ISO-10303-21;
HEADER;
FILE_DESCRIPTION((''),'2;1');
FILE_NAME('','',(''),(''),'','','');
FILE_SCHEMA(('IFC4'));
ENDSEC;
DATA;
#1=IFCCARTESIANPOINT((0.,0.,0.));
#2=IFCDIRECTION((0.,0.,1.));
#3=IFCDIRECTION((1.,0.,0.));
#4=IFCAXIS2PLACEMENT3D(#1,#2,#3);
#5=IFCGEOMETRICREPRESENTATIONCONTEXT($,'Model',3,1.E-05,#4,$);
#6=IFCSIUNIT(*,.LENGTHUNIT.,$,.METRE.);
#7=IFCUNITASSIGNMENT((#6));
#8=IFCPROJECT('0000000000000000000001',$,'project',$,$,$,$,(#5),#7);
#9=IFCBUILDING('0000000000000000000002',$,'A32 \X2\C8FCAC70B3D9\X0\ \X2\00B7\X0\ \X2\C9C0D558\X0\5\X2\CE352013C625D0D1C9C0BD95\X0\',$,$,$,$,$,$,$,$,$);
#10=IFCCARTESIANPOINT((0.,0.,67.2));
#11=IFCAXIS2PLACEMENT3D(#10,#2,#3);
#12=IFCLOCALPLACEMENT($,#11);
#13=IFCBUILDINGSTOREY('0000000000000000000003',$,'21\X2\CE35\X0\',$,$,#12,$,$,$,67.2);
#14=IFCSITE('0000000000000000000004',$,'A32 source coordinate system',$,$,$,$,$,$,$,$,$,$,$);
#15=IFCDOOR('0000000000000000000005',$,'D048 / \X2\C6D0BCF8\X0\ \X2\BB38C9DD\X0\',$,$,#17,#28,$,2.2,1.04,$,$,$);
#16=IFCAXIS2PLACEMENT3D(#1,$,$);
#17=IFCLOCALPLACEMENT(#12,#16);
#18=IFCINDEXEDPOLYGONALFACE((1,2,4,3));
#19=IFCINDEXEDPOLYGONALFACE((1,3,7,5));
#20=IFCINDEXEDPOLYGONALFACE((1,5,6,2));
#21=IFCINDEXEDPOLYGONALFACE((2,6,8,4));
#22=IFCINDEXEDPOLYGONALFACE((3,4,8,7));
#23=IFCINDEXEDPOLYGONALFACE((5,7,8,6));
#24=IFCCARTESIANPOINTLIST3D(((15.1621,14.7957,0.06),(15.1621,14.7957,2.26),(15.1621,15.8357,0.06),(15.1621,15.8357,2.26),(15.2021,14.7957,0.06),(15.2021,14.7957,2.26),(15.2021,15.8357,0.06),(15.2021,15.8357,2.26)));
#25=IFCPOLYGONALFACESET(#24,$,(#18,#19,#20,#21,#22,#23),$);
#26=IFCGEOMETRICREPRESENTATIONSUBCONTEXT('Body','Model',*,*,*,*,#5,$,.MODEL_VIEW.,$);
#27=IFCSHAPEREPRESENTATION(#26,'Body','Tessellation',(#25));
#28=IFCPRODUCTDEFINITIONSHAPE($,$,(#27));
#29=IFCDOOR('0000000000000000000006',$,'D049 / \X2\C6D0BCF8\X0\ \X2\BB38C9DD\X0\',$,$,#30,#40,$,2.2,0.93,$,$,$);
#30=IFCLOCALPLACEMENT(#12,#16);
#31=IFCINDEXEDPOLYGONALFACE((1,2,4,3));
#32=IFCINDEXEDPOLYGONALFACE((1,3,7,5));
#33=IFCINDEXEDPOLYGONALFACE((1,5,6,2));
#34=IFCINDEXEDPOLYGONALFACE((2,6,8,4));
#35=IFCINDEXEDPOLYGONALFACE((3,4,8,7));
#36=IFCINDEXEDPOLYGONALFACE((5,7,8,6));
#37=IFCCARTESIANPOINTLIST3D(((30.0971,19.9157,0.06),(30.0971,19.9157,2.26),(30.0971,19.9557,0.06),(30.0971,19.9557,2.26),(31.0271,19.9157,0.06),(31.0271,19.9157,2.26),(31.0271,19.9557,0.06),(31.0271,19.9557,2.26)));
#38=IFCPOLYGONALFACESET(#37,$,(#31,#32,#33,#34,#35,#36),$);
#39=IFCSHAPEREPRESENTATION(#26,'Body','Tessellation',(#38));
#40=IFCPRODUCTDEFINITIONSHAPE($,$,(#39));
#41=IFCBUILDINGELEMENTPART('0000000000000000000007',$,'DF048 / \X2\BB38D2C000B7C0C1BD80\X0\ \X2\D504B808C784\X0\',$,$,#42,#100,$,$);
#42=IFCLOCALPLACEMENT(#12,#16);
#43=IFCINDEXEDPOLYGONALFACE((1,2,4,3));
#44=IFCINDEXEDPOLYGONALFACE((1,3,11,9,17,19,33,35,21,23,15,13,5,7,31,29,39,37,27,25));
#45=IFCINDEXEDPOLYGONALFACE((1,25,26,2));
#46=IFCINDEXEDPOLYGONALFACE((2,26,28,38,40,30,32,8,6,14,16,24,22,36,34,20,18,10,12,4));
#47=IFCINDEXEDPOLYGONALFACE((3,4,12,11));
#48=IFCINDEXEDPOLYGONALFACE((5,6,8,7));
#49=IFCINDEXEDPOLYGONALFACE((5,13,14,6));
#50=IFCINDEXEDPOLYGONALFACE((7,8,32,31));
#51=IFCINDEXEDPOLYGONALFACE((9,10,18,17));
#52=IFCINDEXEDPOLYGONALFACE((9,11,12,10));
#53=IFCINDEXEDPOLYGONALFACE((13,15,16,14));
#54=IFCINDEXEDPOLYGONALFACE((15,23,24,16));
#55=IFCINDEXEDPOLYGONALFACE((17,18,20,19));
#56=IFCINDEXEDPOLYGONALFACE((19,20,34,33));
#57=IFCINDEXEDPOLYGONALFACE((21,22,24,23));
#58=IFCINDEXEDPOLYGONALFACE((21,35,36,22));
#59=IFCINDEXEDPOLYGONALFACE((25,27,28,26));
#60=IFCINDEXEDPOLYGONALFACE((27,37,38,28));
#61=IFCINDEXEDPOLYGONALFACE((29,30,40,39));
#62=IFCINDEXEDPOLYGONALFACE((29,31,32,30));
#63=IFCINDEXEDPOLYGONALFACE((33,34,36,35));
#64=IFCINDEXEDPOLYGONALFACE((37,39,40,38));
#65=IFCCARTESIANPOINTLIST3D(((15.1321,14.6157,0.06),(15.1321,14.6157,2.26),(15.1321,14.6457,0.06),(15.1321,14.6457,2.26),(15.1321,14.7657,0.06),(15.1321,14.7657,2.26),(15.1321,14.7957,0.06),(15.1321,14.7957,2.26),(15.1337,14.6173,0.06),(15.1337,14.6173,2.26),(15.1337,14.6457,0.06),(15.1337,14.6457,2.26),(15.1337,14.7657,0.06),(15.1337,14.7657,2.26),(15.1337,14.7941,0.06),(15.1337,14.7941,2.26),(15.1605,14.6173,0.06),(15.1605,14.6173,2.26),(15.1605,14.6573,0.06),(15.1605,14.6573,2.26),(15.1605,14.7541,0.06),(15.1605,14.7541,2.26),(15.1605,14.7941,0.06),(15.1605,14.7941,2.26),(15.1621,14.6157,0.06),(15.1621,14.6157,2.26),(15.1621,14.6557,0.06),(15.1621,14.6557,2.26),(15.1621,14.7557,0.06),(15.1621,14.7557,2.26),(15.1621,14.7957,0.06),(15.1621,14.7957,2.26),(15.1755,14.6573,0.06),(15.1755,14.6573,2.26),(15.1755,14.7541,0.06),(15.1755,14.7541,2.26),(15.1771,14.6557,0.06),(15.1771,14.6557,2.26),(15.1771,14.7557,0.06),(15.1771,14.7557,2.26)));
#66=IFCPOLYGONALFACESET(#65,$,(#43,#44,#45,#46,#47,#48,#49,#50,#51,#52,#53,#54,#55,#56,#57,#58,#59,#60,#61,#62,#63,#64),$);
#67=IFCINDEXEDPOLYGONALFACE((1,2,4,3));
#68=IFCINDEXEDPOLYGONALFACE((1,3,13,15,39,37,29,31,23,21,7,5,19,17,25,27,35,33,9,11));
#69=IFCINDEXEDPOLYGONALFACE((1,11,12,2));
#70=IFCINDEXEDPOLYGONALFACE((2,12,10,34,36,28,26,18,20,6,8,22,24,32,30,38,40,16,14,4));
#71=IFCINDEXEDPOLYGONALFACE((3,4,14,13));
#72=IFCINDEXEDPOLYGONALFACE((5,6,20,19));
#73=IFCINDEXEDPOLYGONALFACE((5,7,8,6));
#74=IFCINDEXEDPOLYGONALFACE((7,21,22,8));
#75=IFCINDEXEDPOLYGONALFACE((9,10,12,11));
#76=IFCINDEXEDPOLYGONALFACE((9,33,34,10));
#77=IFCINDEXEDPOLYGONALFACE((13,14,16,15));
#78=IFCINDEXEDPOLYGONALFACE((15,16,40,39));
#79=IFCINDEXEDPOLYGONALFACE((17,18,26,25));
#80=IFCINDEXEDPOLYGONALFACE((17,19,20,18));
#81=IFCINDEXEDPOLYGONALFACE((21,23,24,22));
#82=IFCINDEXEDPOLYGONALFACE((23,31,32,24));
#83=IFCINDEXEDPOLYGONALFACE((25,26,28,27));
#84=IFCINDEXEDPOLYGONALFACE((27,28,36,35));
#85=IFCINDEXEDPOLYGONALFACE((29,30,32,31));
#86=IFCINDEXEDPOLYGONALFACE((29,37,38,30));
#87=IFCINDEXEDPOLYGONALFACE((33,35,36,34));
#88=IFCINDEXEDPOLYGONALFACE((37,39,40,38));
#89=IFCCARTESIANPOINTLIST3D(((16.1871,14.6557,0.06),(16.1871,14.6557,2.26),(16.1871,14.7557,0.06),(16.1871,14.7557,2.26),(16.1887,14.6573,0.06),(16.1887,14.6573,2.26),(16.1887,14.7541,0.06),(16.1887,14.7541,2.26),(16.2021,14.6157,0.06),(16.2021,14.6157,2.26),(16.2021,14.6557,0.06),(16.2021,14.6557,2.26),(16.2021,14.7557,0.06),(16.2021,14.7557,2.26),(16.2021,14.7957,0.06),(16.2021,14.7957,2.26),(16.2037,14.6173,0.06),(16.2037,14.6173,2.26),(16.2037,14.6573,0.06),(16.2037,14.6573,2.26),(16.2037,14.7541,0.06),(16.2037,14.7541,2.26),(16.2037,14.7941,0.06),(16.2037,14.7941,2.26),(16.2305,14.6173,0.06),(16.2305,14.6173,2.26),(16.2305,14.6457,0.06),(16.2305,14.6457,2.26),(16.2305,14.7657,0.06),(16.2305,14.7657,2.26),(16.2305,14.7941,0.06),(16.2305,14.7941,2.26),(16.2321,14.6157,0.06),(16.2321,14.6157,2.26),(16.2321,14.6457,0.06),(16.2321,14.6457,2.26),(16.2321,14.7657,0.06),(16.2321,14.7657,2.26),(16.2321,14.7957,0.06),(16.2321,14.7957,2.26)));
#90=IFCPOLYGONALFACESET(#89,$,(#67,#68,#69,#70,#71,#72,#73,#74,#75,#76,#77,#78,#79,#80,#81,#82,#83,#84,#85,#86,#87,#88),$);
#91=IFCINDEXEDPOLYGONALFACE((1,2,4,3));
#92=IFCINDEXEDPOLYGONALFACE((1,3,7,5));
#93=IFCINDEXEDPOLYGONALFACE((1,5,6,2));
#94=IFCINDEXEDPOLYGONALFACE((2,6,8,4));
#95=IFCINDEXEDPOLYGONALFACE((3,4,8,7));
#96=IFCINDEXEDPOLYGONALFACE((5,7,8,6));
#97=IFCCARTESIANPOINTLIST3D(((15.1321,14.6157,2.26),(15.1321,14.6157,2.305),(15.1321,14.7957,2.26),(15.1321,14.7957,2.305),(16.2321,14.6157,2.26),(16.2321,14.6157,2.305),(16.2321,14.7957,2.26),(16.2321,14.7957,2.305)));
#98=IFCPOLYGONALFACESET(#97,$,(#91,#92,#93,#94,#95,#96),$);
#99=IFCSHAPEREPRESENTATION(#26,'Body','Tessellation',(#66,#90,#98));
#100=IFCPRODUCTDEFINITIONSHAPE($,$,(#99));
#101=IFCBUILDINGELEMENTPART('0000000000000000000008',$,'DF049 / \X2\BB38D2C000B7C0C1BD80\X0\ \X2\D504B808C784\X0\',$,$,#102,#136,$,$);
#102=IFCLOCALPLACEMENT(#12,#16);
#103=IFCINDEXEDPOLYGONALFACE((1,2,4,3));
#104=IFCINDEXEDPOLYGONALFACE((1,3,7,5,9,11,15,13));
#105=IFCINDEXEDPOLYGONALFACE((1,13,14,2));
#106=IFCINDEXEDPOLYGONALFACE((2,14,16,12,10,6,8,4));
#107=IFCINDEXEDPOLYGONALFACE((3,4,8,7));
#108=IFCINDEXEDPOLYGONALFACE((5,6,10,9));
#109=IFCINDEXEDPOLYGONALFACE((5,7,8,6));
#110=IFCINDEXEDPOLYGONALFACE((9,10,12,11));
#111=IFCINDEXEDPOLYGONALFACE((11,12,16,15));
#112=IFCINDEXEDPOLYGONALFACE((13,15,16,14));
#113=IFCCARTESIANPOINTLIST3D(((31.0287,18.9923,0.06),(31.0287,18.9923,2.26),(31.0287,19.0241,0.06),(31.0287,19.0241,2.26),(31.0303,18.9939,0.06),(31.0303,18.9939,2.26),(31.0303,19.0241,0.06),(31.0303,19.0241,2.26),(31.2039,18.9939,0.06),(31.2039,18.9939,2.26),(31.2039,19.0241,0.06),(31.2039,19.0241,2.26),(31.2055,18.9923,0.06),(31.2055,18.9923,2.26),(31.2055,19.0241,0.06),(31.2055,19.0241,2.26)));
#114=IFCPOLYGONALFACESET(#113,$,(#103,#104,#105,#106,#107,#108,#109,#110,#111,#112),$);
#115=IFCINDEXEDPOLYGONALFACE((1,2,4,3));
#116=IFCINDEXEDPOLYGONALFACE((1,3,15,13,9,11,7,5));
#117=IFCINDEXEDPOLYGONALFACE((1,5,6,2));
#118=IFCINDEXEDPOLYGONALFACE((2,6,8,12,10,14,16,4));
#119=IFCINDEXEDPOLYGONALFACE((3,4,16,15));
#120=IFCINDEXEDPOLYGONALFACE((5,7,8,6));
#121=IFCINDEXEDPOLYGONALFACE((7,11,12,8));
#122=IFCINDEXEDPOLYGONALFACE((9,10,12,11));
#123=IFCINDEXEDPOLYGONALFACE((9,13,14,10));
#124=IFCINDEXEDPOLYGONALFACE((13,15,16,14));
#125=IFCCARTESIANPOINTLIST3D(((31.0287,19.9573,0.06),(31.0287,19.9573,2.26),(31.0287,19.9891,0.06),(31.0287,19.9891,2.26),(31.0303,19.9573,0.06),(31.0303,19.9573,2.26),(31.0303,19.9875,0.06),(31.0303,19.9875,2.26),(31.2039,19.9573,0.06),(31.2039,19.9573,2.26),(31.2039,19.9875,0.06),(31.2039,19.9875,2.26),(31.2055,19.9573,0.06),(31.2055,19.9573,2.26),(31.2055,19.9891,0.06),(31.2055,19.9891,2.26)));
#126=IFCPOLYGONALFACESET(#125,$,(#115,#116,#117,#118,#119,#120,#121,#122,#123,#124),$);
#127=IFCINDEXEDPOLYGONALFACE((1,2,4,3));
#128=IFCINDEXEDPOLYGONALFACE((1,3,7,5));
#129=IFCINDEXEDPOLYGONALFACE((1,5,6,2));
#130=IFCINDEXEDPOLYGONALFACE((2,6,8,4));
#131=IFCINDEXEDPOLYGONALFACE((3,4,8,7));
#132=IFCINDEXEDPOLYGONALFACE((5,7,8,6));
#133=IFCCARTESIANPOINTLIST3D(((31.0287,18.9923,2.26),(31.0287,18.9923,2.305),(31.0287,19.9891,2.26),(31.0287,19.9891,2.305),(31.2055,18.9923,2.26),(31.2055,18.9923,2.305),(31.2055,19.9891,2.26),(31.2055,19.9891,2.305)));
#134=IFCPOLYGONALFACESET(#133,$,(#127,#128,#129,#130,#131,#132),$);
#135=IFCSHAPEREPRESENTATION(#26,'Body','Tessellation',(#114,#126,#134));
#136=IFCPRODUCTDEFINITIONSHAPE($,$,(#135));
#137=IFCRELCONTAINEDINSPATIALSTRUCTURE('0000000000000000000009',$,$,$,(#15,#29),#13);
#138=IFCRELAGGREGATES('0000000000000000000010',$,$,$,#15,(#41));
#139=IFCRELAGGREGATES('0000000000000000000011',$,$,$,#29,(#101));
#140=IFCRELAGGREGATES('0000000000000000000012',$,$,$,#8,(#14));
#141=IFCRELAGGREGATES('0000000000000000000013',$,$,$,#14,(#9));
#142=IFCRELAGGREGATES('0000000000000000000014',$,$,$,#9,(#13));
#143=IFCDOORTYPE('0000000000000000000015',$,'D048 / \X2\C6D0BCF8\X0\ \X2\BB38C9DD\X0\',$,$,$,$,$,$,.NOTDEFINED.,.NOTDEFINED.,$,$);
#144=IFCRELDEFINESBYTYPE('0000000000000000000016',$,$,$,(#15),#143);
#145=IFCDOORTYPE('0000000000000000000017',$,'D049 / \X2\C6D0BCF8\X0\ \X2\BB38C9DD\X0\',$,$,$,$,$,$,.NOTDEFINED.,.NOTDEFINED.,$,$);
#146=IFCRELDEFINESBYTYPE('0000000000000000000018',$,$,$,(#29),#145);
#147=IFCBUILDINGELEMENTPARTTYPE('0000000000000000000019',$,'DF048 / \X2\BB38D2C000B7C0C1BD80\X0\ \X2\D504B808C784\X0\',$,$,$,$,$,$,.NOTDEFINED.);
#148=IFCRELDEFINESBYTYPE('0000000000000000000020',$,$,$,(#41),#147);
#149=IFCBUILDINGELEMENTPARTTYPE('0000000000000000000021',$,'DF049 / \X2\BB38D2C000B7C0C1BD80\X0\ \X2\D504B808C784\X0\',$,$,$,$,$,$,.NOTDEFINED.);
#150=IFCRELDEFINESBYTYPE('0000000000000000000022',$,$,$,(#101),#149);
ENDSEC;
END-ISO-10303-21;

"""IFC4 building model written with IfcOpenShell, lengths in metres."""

from ifc_helpers import new_model, si_unit, frame, origin, origin_with_axes, place, context, subcontext, project, spatial, polyline, outline, extrude, source, transform, mapped, type_object, type_shapes, element, aggregate, save


model = new_model("IFC4")

# Units and contexts
model_context = context("Model", 3, precision=1e-05, world=origin_with_axes())
body_context = subcontext(model_context, "Body", "Model", "MODEL_VIEW")
ifc_project = project(units=[si_unit("LENGTHUNIT", "METRE")], contexts=[model_context])

# Site, building, storey
storey_placement = place(None, frame((0.0, 0.0, 67.2), z_axis=(0.0, 0.0, 1.0), x_axis=(1.0, 0.0, 0.0)))
site = spatial("IfcSite", under=ifc_project, Name="A32 source coordinate system")
building = spatial("IfcBuilding", under=site, Name="A32 주거동 · 지하5층–옥탑지붕")
storey = spatial("IfcBuildingStorey", under=building, at=storey_placement, Name="21층", Elevation=67.2)

# Doors
door_type_1 = type_object("IfcDoorType", Name="D048 / 원본 문짝", OperationType="NOTDEFINED", PredefinedType="NOTDEFINED")
shared_shape_1 = source(origin(), body_context, "Body", "SweptSolid", [
    extrude(outline(polyline([(15.2021, 15.8357), (15.2021, 14.7957), (15.1621, 14.7957), (15.1621, 15.8357), (15.2021, 15.8357)])), frame((0.0, 0.0, 0.06)), (0.0, 0.0, 1.0), 2.2),
])
type_shapes(door_type_1, [shared_shape_1])
door_1_placement = place(storey_placement, origin_with_axes())
door_1 = element("IfcDoor", 1, at=door_1_placement, inside=storey, type_object=door_type_1, Name="D048 / 원본 문짝", OverallHeight=2.2, OverallWidth=1.04, context=body_context, shape_type="MappedRepresentation", body=[
    mapped(shared_shape_1, transform((0.0, 0.0, 0.0), scale=1.0)),
])
door_type_2 = type_object("IfcDoorType", Name="D049 / 원본 문짝", OperationType="NOTDEFINED", PredefinedType="NOTDEFINED")
shared_shape_2 = source(origin(), body_context, "Body", "SweptSolid", [
    extrude(outline(polyline([(31.0271, 19.9557), (31.0271, 19.9157), (30.0971, 19.9157), (30.0971, 19.9557), (31.0271, 19.9557)])), frame((0.0, 0.0, 0.06)), (0.0, 0.0, 1.0), 2.2),
])
type_shapes(door_type_2, [shared_shape_2])
door_2_placement = place(storey_placement, origin_with_axes())
door_2 = element("IfcDoor", 2, at=door_2_placement, inside=storey, type_object=door_type_2, Name="D049 / 원본 문짝", OverallHeight=2.2, OverallWidth=0.93, context=body_context, shape_type="MappedRepresentation", body=[
    mapped(shared_shape_2, transform((0.0, 0.0, 0.0), scale=1.0)),
])

# Building element parts
building_element_part_type_1 = type_object("IfcBuildingElementPartType", Name="DF048 / 문틀·상부 프레임", PredefinedType="NOTDEFINED")
shared_shape_3 = source(origin(), body_context, "Body", "SweptSolid", [
    extrude(outline(polyline([(15.1321, 14.7657), (15.1321, 14.7957), (15.1621, 14.7957), (15.1621, 14.7557), (15.1771, 14.7557), (15.1771, 14.6557), (15.1621, 14.6557), (15.1621, 14.6157), (15.1321, 14.6157), (15.1321, 14.6457), (15.1337, 14.6457), (15.1337, 14.6173), (15.1605, 14.6173), (15.1605, 14.6573), (15.1755, 14.6573), (15.1755, 14.7541), (15.1605, 14.7541), (15.1605, 14.7941), (15.1337, 14.7941), (15.1337, 14.7657), (15.1321, 14.7657)])), frame((0.0, 0.0, 0.06)), (0.0, 0.0, 1.0), 2.2),
    extrude(outline(polyline([(16.2305, 14.7941), (16.2037, 14.7941), (16.2037, 14.7541), (16.1887, 14.7541), (16.1887, 14.6573), (16.2037, 14.6573), (16.2037, 14.6173), (16.2305, 14.6173), (16.2305, 14.6457), (16.2321, 14.6457), (16.2321, 14.6157), (16.2021, 14.6157), (16.2021, 14.6557), (16.1871, 14.6557), (16.1871, 14.7557), (16.2021, 14.7557), (16.2021, 14.7957), (16.2321, 14.7957), (16.2321, 14.7657), (16.2305, 14.7657), (16.2305, 14.7941)])), frame((0.0, 0.0, 0.06)), (0.0, 0.0, 1.0), 2.2),
    extrude(outline(polyline([(15.1321, 14.6157), (15.1321, 14.7957), (16.2321, 14.7957), (16.2321, 14.6157), (15.1321, 14.6157)])), frame((0.0, 0.0, 2.26)), (0.0, 0.0, 1.0), 0.045),
])
type_shapes(building_element_part_type_1, [shared_shape_3])
building_element_part_1_placement = place(door_1_placement, origin_with_axes())
building_element_part_1 = element("IfcBuildingElementPart", 3, at=building_element_part_1_placement, type_object=building_element_part_type_1, Name="DF048 / 문틀·상부 프레임", context=body_context, shape_type="MappedRepresentation", body=[
    mapped(shared_shape_3, transform((0.0, 0.0, 0.0), scale=1.0)),
])
aggregate(door_1, [building_element_part_1])
building_element_part_type_2 = type_object("IfcBuildingElementPartType", Name="DF049 / 문틀·상부 프레임", PredefinedType="NOTDEFINED")
shared_shape_4 = source(origin(), body_context, "Body", "SweptSolid", [
    extrude(outline(polyline([(31.0303, 19.0241), (31.0303, 18.9939), (31.2039, 18.9939), (31.2039, 19.0241), (31.2055, 19.0241), (31.2055, 18.9923), (31.0287, 18.9923), (31.0287, 19.0241), (31.0303, 19.0241)])), frame((0.0, 0.0, 0.06)), (0.0, 0.0, 1.0), 2.2),
    extrude(outline(polyline([(31.0287, 19.9891), (31.2055, 19.9891), (31.2055, 19.9573), (31.2039, 19.9573), (31.2039, 19.9875), (31.0303, 19.9875), (31.0303, 19.9573), (31.0287, 19.9573), (31.0287, 19.9891)])), frame((0.0, 0.0, 0.06)), (0.0, 0.0, 1.0), 2.2),
    extrude(outline(polyline([(31.0287, 18.9923), (31.0287, 19.9891), (31.2055, 19.9891), (31.2055, 18.9923), (31.0287, 18.9923)])), frame((0.0, 0.0, 2.26)), (0.0, 0.0, 1.0), 0.045),
])
type_shapes(building_element_part_type_2, [shared_shape_4])
building_element_part_2_placement = place(door_2_placement, origin_with_axes())
building_element_part_2 = element("IfcBuildingElementPart", 4, at=building_element_part_2_placement, type_object=building_element_part_type_2, Name="DF049 / 문틀·상부 프레임", context=body_context, shape_type="MappedRepresentation", body=[
    mapped(shared_shape_4, transform((0.0, 0.0, 0.0), scale=1.0)),
])
aggregate(door_2, [building_element_part_2])

save(model, "model.ifc")
